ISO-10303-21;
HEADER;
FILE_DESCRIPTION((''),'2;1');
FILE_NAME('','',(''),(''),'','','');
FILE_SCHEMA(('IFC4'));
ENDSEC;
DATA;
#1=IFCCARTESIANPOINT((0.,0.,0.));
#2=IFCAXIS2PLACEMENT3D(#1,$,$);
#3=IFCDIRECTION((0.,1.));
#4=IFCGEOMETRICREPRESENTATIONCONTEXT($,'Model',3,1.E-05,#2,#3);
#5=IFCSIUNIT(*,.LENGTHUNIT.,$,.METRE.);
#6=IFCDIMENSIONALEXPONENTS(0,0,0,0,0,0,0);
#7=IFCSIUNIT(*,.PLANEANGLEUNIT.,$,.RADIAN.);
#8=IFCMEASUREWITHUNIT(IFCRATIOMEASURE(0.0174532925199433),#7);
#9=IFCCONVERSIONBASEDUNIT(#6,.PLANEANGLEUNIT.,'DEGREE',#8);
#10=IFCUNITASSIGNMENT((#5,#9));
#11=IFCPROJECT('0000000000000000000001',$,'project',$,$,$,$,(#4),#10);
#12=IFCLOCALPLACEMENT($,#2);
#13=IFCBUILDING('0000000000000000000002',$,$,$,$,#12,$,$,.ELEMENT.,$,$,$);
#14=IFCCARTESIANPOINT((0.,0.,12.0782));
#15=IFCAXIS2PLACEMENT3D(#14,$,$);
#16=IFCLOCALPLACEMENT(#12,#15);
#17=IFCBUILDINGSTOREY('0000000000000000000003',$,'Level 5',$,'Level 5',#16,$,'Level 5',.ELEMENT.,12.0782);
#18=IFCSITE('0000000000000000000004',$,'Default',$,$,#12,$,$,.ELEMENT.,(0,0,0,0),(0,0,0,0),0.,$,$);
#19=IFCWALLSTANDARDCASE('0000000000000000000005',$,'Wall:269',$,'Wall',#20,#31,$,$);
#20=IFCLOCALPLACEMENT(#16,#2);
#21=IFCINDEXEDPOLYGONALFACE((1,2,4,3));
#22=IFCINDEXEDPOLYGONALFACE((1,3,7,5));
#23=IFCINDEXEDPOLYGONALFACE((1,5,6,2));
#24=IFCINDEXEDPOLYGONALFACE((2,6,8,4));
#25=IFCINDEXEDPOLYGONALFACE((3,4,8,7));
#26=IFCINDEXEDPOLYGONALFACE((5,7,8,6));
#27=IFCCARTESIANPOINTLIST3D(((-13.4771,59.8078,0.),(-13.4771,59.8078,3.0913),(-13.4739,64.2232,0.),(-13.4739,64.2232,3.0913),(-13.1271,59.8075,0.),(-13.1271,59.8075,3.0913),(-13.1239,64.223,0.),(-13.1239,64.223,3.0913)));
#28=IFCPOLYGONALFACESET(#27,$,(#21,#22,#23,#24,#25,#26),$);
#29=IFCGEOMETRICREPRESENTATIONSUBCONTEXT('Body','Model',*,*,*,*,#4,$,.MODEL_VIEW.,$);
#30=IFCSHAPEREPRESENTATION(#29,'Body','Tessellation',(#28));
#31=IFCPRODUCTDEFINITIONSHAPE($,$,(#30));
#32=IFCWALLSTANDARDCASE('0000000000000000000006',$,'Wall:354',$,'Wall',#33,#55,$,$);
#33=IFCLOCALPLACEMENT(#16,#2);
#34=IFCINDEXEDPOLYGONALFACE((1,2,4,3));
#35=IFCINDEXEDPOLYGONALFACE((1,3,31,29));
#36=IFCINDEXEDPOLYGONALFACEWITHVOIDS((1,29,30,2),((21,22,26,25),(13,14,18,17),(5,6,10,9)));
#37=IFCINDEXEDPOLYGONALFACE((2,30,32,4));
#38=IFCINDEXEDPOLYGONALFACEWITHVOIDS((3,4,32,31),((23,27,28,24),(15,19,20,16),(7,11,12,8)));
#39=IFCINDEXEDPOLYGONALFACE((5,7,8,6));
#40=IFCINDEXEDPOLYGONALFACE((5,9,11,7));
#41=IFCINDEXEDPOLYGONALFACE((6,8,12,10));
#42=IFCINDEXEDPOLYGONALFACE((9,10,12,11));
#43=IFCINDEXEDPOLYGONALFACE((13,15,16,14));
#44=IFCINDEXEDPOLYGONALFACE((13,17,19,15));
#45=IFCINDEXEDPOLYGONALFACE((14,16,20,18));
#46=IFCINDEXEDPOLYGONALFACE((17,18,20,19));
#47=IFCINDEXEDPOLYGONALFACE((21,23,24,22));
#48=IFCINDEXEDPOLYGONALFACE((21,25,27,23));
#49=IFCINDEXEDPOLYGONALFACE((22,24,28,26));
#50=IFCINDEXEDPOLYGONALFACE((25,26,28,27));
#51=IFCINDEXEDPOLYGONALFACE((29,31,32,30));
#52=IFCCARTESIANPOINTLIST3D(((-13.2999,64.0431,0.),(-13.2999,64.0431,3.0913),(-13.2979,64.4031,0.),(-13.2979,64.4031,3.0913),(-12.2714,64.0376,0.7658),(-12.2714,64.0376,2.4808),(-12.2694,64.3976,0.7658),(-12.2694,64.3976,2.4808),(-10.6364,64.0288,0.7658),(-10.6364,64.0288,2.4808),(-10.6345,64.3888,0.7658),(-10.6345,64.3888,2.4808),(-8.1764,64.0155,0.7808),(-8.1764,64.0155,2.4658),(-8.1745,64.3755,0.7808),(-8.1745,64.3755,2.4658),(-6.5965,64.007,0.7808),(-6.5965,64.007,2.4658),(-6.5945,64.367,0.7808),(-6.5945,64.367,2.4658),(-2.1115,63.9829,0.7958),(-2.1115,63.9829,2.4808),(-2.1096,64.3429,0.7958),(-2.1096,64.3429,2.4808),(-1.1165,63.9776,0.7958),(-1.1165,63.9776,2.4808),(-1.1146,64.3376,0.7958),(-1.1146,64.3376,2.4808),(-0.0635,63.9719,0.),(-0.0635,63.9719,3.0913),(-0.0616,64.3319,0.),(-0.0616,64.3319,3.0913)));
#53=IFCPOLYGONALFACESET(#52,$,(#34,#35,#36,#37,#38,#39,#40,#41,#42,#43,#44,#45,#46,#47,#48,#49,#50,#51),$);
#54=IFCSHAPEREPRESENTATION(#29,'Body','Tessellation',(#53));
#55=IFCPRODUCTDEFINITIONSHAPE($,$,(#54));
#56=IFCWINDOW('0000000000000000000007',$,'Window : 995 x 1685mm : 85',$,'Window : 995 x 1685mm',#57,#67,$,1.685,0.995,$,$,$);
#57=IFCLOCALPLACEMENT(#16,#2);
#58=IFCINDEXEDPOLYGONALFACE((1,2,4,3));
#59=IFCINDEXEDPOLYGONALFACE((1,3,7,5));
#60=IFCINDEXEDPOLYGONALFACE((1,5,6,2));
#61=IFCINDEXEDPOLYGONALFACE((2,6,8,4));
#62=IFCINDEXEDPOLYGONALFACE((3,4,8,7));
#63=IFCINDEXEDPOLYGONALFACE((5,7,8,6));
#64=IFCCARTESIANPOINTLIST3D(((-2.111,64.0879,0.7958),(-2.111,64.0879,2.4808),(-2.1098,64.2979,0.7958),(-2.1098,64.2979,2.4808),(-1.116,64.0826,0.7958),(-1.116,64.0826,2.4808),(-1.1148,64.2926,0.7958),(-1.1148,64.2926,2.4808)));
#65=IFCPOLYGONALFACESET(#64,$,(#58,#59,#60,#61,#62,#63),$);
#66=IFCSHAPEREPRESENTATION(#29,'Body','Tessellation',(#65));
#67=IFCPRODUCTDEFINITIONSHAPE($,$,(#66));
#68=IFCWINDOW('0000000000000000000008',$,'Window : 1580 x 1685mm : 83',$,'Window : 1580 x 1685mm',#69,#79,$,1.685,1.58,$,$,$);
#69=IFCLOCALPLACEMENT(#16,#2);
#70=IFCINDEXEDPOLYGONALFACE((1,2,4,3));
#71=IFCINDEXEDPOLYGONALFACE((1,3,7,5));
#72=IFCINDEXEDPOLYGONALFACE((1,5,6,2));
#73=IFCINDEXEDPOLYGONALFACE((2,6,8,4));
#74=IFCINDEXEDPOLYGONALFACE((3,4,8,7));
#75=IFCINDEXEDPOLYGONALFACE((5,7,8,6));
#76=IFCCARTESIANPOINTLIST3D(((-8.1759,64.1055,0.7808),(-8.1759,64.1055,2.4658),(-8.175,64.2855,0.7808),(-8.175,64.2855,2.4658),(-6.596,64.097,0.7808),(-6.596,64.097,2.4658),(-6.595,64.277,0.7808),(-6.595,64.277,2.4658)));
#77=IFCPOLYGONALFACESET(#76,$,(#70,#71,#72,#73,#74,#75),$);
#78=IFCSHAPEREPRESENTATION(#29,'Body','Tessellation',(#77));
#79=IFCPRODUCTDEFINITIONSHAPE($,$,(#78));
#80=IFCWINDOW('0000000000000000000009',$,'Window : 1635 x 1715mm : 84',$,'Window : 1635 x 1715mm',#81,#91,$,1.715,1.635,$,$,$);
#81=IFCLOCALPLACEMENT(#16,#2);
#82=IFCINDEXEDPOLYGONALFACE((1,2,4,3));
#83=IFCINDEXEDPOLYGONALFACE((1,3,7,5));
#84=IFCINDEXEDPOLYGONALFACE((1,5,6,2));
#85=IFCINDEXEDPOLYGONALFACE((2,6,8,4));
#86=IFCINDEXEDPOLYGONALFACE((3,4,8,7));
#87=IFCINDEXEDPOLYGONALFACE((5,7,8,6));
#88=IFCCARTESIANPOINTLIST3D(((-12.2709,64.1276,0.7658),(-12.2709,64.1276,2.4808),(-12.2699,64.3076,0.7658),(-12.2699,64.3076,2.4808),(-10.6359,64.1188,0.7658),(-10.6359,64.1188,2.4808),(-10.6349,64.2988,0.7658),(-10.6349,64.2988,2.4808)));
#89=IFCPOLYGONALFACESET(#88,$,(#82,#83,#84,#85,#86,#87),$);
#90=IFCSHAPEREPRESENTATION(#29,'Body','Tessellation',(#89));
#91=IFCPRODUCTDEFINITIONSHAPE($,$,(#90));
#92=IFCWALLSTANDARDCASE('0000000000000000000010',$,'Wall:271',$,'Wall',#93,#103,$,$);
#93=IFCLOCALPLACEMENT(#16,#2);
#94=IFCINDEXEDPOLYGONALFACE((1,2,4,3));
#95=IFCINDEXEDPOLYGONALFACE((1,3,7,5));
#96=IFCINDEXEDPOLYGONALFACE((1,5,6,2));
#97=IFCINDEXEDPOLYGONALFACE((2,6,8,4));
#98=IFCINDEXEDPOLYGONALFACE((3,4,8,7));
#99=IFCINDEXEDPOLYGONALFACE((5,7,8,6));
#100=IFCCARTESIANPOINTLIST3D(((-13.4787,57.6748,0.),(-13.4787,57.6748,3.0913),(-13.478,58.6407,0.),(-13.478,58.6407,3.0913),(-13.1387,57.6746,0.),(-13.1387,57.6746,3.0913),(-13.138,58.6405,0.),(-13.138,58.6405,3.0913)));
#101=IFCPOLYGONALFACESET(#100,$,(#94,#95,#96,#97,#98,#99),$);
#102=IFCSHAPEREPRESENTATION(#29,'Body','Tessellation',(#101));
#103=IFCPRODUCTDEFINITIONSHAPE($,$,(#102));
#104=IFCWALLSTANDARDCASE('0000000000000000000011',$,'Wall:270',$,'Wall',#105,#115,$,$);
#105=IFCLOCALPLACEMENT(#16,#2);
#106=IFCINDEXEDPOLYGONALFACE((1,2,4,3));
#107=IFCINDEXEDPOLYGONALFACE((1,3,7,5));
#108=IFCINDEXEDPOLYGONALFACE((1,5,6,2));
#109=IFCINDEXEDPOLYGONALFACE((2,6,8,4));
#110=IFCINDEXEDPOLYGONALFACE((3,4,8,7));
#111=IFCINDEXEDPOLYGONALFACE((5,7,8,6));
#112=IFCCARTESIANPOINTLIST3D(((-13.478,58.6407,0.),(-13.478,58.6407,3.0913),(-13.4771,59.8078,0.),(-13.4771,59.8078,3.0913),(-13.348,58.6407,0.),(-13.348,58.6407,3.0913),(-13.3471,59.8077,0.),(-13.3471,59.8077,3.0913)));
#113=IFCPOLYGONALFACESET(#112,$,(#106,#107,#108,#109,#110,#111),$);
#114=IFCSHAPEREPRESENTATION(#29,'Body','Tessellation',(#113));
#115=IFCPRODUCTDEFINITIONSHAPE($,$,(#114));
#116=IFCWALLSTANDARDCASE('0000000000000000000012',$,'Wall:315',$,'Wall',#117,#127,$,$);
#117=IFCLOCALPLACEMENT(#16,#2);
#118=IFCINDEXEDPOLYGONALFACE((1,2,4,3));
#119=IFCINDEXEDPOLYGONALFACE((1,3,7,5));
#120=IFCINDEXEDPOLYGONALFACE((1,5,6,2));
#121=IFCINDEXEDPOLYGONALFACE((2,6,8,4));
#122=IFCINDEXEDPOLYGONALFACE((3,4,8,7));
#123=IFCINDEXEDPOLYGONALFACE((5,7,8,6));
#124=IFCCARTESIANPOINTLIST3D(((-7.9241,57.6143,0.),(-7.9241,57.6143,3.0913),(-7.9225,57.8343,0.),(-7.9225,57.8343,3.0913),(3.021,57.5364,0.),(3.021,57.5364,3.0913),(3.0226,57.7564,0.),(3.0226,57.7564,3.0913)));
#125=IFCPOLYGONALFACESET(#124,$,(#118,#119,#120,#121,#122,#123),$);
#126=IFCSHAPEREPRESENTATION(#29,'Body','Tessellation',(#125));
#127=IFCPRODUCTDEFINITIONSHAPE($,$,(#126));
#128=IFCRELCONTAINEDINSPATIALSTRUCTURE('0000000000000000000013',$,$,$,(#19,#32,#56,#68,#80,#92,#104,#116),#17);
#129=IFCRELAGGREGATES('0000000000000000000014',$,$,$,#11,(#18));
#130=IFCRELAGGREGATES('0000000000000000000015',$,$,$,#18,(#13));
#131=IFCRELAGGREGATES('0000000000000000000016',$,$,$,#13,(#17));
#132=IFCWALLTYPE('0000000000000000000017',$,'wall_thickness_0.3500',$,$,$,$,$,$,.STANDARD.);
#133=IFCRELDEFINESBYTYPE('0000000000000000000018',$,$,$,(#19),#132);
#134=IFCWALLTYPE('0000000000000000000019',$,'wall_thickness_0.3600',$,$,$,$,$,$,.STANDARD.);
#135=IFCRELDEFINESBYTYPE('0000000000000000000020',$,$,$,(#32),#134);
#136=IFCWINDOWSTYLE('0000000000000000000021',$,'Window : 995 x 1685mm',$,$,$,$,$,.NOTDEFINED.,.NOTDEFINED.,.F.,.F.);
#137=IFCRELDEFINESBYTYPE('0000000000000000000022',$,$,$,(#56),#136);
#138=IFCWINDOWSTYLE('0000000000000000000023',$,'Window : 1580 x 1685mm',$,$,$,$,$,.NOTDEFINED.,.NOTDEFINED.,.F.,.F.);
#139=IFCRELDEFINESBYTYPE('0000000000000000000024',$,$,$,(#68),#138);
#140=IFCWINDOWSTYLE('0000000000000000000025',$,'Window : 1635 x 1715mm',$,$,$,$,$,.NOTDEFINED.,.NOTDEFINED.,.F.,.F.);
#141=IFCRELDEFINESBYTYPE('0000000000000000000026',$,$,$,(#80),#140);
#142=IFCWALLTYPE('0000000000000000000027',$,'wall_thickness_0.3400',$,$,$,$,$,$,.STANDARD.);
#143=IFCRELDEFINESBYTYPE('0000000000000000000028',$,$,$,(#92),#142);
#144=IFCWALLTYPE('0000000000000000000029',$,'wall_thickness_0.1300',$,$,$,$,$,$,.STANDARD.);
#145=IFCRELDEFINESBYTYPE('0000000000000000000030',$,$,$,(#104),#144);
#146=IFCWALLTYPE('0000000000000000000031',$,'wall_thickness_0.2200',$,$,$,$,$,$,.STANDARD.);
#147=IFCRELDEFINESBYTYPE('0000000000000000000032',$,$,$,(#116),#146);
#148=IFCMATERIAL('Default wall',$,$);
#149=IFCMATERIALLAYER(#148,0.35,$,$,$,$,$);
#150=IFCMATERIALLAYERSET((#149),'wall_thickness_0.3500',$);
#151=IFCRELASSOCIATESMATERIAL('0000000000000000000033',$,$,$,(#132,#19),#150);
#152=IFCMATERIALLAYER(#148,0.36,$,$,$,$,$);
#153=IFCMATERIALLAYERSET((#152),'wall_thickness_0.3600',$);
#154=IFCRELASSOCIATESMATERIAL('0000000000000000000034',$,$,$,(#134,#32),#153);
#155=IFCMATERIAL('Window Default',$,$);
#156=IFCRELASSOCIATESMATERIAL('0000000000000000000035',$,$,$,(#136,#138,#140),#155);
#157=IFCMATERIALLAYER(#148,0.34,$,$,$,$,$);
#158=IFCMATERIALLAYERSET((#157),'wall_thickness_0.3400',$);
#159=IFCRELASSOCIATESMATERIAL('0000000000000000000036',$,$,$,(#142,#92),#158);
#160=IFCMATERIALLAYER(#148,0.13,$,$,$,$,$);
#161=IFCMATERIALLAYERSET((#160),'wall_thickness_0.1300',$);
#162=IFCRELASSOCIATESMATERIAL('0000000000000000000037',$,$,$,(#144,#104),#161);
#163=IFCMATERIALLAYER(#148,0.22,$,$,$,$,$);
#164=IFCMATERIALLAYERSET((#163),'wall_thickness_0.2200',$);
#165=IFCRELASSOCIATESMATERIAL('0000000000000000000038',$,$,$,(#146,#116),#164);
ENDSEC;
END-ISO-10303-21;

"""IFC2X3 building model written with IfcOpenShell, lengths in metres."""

from ifc_helpers import new_model, entity, si_unit, converted_unit, direction, frame, frame_2d, origin, origin_2d_with_axis, place, context, subcontext, project, spatial, polyline, rectangle, outline, extrude, clip, halfspace, source, transform, mapped, material, layer, layer_set, layer_usage, type_object, type_shapes, element, fill, save


model = new_model("IFC2X3")

# Units and contexts
model_context = context("Model", 3, precision=1e-05, world=origin(), true_north=direction((0.0, 1.0)))
body_context = subcontext(model_context, "Body", "Model", "MODEL_VIEW")
ifc_project = project(units=[si_unit("LENGTHUNIT", "METRE"), converted_unit("PLANEANGLEUNIT", "DEGREE", entity("IfcRatioMeasure", 0.0174532925199433), si_unit("PLANEANGLEUNIT", "RADIAN"), dimensions=[0, 0, 0, 0, 0, 0, 0])], contexts=[model_context])

# Site, building, storey
placement_1 = place(None, origin())
site = spatial("IfcSite", under=ifc_project, at=placement_1, Name="Default", CompositionType="ELEMENT", RefLatitude=(0, 0, 0, 0), RefLongitude=(0, 0, 0, 0), RefElevation=0.0)
building = spatial("IfcBuilding", under=site, at=placement_1, CompositionType="ELEMENT")
storey_placement = place(placement_1, frame((0.0, 0.0, 12.0782)))
storey = spatial("IfcBuildingStorey", under=building, at=storey_placement, Name="Level 5", ObjectType="Level 5", LongName="Level 5", CompositionType="ELEMENT", Elevation=12.0782)

# Wall
ifc_material_1 = material(Name="Default wall")
ifc_layer_1 = layer(ifc_material_1, 0.35)
ifc_layer_set_1 = layer_set([ifc_layer_1], Name="wall_thickness_0.3500")
ifc_layer_usage_1 = layer_usage(ifc_layer_set_1, "AXIS2", "POSITIVE", -0.175)
wall_type_1 = type_object("IfcWallType", Name="wall_thickness_0.3500", PredefinedType="STANDARD", material=ifc_layer_set_1)
wall_1_placement = place(storey_placement, frame((-13.2989, 64.2231, 0.0), z_axis=(0.0, 0.0, 1.0), x_axis=(-0.000733, -1.0, 0.0)))
element("IfcWallStandardCase", 1, at=wall_1_placement, inside=storey, type_object=wall_type_1, material=ifc_layer_usage_1, Name="Wall:269", ObjectType="Wall", context=body_context, shape_type="SweptSolid", body=[
    extrude(outline(polyline([(4.4155, -0.175), (4.4155, 0.175), (0.0, 0.175), (0.0, -0.175), (4.4155, -0.175)])), origin(), (0.0, 0.0, 1.0), 3.0913),
])

# Wall, openings, windows
ifc_layer_2 = layer(ifc_material_1, 0.36)
ifc_layer_set_2 = layer_set([ifc_layer_2], Name="wall_thickness_0.3600")
ifc_layer_usage_2 = layer_usage(ifc_layer_set_2, "AXIS2", "POSITIVE", -0.18)
wall_type_2 = type_object("IfcWallType", Name="wall_thickness_0.3600", PredefinedType="STANDARD", material=ifc_layer_set_2)
wall_2_placement = place(storey_placement, frame((-13.2989, 64.2231, 0.0), z_axis=(0.0, 0.0, 1.0), x_axis=(0.999986, -0.005379, 0.0)))
wall_2 = element("IfcWallStandardCase", 2, at=wall_2_placement, inside=storey, type_object=wall_type_2, material=ifc_layer_usage_2, Name="Wall:354", ObjectType="Wall", context=body_context, shape_type="Clipping", body=[
    clip(extrude(outline(polyline([(13.2365, -0.18), (13.2365, 0.18), (0.0, 0.18), (0.0, -0.18), (13.2365, -0.18)])), origin(), (0.0, 0.0, 1.0), 3.0913), halfspace(frame((37.9612, -6.5164, 9.0135), z_axis=(0.000378, 0.389455, 0.921045), x_axis=(-0.999996, 0.002767, -0.000759)), False)),
])
opening_1_placement = place(wall_2_placement, frame((5.1235, -0.18, 0.7808)))
opening_1 = element("IfcOpeningElement", 3, at=opening_1_placement, cuts=wall_2, ObjectType="Opening", context=body_context, shape_type="SweptSolid", body=[
    extrude(rectangle(XDim=1.58, YDim=1.685, at=frame_2d((0.8425, 0.79), x_axis=(0.0, 1.0))), frame((0.0, 0.0, 0.0), z_axis=(0.0, 1.0, 0.0), x_axis=(0.0, 0.0, 1.0)), (0.0, 0.0, 1.0), 0.36),
])
opening_2_placement = place(wall_2_placement, frame((1.0285, -0.18, 0.7658)))
opening_2 = element("IfcOpeningElement", 4, at=opening_2_placement, cuts=wall_2, ObjectType="Opening", context=body_context, shape_type="SweptSolid", body=[
    extrude(rectangle(XDim=1.635, YDim=1.715, at=frame_2d((0.8575, 0.8175), x_axis=(0.0, 1.0))), frame((0.0, 0.0, 0.0), z_axis=(0.0, 1.0, 0.0), x_axis=(0.0, 0.0, 1.0)), (0.0, 0.0, 1.0), 0.36),
])
opening_3_placement = place(wall_2_placement, frame((11.1885, -0.18, 0.7958)))
opening_3 = element("IfcOpeningElement", 5, at=opening_3_placement, cuts=wall_2, ObjectType="Opening", context=body_context, shape_type="SweptSolid", body=[
    extrude(rectangle(XDim=0.995, YDim=1.685, at=frame_2d((0.8425, 0.4975), x_axis=(0.0, 1.0))), frame((0.0, 0.0, 0.0), z_axis=(0.0, 1.0, 0.0), x_axis=(0.0, 0.0, 1.0)), (0.0, 0.0, 1.0), 0.36),
])
ifc_material_2 = material(Name="Window Default")
window_style_1 = type_object("IfcWindowStyle", Name="Window : 995 x 1685mm", ConstructionType="NOTDEFINED", OperationType="NOTDEFINED", ParameterTakesPrecedence=False, Sizeable=False, material=ifc_material_2)
shared_shape_1 = source(origin(), body_context, "Body", "SweptSolid", [
    extrude(rectangle(XDim=0.21, YDim=0.995, at=origin_2d_with_axis()), frame((0.4975, 0.21, 0.0), z_axis=(0.0, 0.0, 1.0), x_axis=(0.0, 1.0, 0.0)), (0.0, 0.0, 1.0), 1.685),
])
type_shapes(window_style_1, [shared_shape_1])
window_1_placement = place(opening_3_placement, origin())
window_1 = element("IfcWindow", 6, at=window_1_placement, inside=storey, type_object=window_style_1, Name="Window : 995 x 1685mm : 85", ObjectType="Window : 995 x 1685mm", OverallHeight=1.685, OverallWidth=0.995, context=body_context, shape_type="MappedRepresentation", body=[
    mapped(shared_shape_1, transform((0.0, 0.0, 0.0), scale=1.0)),
])
fill(opening_3, window_1)
window_style_2 = type_object("IfcWindowStyle", Name="Window : 1580 x 1685mm", ConstructionType="NOTDEFINED", OperationType="NOTDEFINED", ParameterTakesPrecedence=False, Sizeable=False, material=ifc_material_2)
shared_shape_2 = source(origin(), body_context, "Body", "SweptSolid", [
    extrude(rectangle(XDim=0.18, YDim=1.58, at=origin_2d_with_axis()), frame((0.79, 0.18, 0.0), z_axis=(0.0, 0.0, 1.0), x_axis=(0.0, 1.0, 0.0)), (0.0, 0.0, 1.0), 1.685),
])
type_shapes(window_style_2, [shared_shape_2])
window_2_placement = place(opening_1_placement, origin())
window_2 = element("IfcWindow", 7, at=window_2_placement, inside=storey, type_object=window_style_2, Name="Window : 1580 x 1685mm : 83", ObjectType="Window : 1580 x 1685mm", OverallHeight=1.685, OverallWidth=1.58, context=body_context, shape_type="MappedRepresentation", body=[
    mapped(shared_shape_2, transform((0.0, 0.0, 0.0), scale=1.0)),
])
fill(opening_1, window_2)
window_style_3 = type_object("IfcWindowStyle", Name="Window : 1635 x 1715mm", ConstructionType="NOTDEFINED", OperationType="NOTDEFINED", ParameterTakesPrecedence=False, Sizeable=False, material=ifc_material_2)
shared_shape_3 = source(origin(), body_context, "Body", "SweptSolid", [
    extrude(rectangle(XDim=0.18, YDim=1.635, at=origin_2d_with_axis()), frame((0.8175, 0.18, 0.0), z_axis=(0.0, 0.0, 1.0), x_axis=(0.0, 1.0, 0.0)), (0.0, 0.0, 1.0), 1.715),
])
type_shapes(window_style_3, [shared_shape_3])
window_3_placement = place(opening_2_placement, origin())
window_3 = element("IfcWindow", 8, at=window_3_placement, inside=storey, type_object=window_style_3, Name="Window : 1635 x 1715mm : 84", ObjectType="Window : 1635 x 1715mm", OverallHeight=1.715, OverallWidth=1.635, context=body_context, shape_type="MappedRepresentation", body=[
    mapped(shared_shape_3, transform((0.0, 0.0, 0.0), scale=1.0)),
])
fill(opening_2, window_3)

# Walls
ifc_layer_3 = layer(ifc_material_1, 0.34)
ifc_layer_set_3 = layer_set([ifc_layer_3], Name="wall_thickness_0.3400")
ifc_layer_usage_3 = layer_usage(ifc_layer_set_3, "AXIS2", "POSITIVE", -0.17)
wall_type_3 = type_object("IfcWallType", Name="wall_thickness_0.3400", PredefinedType="STANDARD", material=ifc_layer_set_3)
wall_3_placement = place(storey_placement, frame((-13.308, 58.6406, 0.0), z_axis=(0.0, 0.0, 1.0), x_axis=(-0.000733, -1.0, 0.0)))
element("IfcWallStandardCase", 9, at=wall_3_placement, inside=storey, type_object=wall_type_3, material=ifc_layer_usage_3, Name="Wall:271", ObjectType="Wall", context=body_context, shape_type="SweptSolid", body=[
    extrude(outline(polyline([(0.9659, -0.17), (0.9659, 0.17), (0.0, 0.17), (0.0, -0.17), (0.9659, -0.17)])), origin(), (0.0, 0.0, 1.0), 3.0913),
])
ifc_layer_4 = layer(ifc_material_1, 0.13)
ifc_layer_set_4 = layer_set([ifc_layer_4], Name="wall_thickness_0.1300")
ifc_layer_usage_4 = layer_usage(ifc_layer_set_4, "AXIS2", "POSITIVE", -0.065)
wall_type_4 = type_object("IfcWallType", Name="wall_thickness_0.1300", PredefinedType="STANDARD", material=ifc_layer_set_4)
wall_4_placement = place(storey_placement, frame((-13.4121, 59.8077, 0.0), z_axis=(0.0, 0.0, 1.0), x_axis=(-0.000734, -1.0, 0.0)))
element("IfcWallStandardCase", 10, at=wall_4_placement, inside=storey, type_object=wall_type_4, material=ifc_layer_usage_4, Name="Wall:270", ObjectType="Wall", context=body_context, shape_type="SweptSolid", body=[
    extrude(outline(polyline([(1.167, -0.065), (1.167, 0.065), (0.0, 0.065), (0.0, -0.065), (1.167, -0.065)])), origin(), (0.0, 0.0, 1.0), 3.0913),
])
ifc_layer_5 = layer(ifc_material_1, 0.22)
ifc_layer_set_5 = layer_set([ifc_layer_5], Name="wall_thickness_0.2200")
ifc_layer_usage_5 = layer_usage(ifc_layer_set_5, "AXIS2", "POSITIVE", -0.11)
wall_type_5 = type_object("IfcWallType", Name="wall_thickness_0.2200", PredefinedType="STANDARD", material=ifc_layer_set_5)
wall_5_placement = place(storey_placement, frame((-7.9233, 57.7243, 0.0), z_axis=(0.0, 0.0, 1.0), x_axis=(0.999975, -0.007117, 0.0)))
element("IfcWallStandardCase", 11, at=wall_5_placement, inside=storey, type_object=wall_type_5, material=ifc_layer_usage_5, Name="Wall:315", ObjectType="Wall", context=body_context, shape_type="Clipping", body=[
    clip(extrude(outline(polyline([(10.9454, -0.11), (10.9454, 0.11), (0.0, 0.11), (0.0, -0.11), (10.9454, -0.11)])), origin(), (0.0, 0.0, 1.0), 3.0913), halfspace(frame((-4.8304, 0.0484, 9.0175), z_axis=(-0.001101, -0.391127, 0.920336), x_axis=(0.999999, -0.001028, 0.000759)), False)),
])

save(model, "model.ifc")
